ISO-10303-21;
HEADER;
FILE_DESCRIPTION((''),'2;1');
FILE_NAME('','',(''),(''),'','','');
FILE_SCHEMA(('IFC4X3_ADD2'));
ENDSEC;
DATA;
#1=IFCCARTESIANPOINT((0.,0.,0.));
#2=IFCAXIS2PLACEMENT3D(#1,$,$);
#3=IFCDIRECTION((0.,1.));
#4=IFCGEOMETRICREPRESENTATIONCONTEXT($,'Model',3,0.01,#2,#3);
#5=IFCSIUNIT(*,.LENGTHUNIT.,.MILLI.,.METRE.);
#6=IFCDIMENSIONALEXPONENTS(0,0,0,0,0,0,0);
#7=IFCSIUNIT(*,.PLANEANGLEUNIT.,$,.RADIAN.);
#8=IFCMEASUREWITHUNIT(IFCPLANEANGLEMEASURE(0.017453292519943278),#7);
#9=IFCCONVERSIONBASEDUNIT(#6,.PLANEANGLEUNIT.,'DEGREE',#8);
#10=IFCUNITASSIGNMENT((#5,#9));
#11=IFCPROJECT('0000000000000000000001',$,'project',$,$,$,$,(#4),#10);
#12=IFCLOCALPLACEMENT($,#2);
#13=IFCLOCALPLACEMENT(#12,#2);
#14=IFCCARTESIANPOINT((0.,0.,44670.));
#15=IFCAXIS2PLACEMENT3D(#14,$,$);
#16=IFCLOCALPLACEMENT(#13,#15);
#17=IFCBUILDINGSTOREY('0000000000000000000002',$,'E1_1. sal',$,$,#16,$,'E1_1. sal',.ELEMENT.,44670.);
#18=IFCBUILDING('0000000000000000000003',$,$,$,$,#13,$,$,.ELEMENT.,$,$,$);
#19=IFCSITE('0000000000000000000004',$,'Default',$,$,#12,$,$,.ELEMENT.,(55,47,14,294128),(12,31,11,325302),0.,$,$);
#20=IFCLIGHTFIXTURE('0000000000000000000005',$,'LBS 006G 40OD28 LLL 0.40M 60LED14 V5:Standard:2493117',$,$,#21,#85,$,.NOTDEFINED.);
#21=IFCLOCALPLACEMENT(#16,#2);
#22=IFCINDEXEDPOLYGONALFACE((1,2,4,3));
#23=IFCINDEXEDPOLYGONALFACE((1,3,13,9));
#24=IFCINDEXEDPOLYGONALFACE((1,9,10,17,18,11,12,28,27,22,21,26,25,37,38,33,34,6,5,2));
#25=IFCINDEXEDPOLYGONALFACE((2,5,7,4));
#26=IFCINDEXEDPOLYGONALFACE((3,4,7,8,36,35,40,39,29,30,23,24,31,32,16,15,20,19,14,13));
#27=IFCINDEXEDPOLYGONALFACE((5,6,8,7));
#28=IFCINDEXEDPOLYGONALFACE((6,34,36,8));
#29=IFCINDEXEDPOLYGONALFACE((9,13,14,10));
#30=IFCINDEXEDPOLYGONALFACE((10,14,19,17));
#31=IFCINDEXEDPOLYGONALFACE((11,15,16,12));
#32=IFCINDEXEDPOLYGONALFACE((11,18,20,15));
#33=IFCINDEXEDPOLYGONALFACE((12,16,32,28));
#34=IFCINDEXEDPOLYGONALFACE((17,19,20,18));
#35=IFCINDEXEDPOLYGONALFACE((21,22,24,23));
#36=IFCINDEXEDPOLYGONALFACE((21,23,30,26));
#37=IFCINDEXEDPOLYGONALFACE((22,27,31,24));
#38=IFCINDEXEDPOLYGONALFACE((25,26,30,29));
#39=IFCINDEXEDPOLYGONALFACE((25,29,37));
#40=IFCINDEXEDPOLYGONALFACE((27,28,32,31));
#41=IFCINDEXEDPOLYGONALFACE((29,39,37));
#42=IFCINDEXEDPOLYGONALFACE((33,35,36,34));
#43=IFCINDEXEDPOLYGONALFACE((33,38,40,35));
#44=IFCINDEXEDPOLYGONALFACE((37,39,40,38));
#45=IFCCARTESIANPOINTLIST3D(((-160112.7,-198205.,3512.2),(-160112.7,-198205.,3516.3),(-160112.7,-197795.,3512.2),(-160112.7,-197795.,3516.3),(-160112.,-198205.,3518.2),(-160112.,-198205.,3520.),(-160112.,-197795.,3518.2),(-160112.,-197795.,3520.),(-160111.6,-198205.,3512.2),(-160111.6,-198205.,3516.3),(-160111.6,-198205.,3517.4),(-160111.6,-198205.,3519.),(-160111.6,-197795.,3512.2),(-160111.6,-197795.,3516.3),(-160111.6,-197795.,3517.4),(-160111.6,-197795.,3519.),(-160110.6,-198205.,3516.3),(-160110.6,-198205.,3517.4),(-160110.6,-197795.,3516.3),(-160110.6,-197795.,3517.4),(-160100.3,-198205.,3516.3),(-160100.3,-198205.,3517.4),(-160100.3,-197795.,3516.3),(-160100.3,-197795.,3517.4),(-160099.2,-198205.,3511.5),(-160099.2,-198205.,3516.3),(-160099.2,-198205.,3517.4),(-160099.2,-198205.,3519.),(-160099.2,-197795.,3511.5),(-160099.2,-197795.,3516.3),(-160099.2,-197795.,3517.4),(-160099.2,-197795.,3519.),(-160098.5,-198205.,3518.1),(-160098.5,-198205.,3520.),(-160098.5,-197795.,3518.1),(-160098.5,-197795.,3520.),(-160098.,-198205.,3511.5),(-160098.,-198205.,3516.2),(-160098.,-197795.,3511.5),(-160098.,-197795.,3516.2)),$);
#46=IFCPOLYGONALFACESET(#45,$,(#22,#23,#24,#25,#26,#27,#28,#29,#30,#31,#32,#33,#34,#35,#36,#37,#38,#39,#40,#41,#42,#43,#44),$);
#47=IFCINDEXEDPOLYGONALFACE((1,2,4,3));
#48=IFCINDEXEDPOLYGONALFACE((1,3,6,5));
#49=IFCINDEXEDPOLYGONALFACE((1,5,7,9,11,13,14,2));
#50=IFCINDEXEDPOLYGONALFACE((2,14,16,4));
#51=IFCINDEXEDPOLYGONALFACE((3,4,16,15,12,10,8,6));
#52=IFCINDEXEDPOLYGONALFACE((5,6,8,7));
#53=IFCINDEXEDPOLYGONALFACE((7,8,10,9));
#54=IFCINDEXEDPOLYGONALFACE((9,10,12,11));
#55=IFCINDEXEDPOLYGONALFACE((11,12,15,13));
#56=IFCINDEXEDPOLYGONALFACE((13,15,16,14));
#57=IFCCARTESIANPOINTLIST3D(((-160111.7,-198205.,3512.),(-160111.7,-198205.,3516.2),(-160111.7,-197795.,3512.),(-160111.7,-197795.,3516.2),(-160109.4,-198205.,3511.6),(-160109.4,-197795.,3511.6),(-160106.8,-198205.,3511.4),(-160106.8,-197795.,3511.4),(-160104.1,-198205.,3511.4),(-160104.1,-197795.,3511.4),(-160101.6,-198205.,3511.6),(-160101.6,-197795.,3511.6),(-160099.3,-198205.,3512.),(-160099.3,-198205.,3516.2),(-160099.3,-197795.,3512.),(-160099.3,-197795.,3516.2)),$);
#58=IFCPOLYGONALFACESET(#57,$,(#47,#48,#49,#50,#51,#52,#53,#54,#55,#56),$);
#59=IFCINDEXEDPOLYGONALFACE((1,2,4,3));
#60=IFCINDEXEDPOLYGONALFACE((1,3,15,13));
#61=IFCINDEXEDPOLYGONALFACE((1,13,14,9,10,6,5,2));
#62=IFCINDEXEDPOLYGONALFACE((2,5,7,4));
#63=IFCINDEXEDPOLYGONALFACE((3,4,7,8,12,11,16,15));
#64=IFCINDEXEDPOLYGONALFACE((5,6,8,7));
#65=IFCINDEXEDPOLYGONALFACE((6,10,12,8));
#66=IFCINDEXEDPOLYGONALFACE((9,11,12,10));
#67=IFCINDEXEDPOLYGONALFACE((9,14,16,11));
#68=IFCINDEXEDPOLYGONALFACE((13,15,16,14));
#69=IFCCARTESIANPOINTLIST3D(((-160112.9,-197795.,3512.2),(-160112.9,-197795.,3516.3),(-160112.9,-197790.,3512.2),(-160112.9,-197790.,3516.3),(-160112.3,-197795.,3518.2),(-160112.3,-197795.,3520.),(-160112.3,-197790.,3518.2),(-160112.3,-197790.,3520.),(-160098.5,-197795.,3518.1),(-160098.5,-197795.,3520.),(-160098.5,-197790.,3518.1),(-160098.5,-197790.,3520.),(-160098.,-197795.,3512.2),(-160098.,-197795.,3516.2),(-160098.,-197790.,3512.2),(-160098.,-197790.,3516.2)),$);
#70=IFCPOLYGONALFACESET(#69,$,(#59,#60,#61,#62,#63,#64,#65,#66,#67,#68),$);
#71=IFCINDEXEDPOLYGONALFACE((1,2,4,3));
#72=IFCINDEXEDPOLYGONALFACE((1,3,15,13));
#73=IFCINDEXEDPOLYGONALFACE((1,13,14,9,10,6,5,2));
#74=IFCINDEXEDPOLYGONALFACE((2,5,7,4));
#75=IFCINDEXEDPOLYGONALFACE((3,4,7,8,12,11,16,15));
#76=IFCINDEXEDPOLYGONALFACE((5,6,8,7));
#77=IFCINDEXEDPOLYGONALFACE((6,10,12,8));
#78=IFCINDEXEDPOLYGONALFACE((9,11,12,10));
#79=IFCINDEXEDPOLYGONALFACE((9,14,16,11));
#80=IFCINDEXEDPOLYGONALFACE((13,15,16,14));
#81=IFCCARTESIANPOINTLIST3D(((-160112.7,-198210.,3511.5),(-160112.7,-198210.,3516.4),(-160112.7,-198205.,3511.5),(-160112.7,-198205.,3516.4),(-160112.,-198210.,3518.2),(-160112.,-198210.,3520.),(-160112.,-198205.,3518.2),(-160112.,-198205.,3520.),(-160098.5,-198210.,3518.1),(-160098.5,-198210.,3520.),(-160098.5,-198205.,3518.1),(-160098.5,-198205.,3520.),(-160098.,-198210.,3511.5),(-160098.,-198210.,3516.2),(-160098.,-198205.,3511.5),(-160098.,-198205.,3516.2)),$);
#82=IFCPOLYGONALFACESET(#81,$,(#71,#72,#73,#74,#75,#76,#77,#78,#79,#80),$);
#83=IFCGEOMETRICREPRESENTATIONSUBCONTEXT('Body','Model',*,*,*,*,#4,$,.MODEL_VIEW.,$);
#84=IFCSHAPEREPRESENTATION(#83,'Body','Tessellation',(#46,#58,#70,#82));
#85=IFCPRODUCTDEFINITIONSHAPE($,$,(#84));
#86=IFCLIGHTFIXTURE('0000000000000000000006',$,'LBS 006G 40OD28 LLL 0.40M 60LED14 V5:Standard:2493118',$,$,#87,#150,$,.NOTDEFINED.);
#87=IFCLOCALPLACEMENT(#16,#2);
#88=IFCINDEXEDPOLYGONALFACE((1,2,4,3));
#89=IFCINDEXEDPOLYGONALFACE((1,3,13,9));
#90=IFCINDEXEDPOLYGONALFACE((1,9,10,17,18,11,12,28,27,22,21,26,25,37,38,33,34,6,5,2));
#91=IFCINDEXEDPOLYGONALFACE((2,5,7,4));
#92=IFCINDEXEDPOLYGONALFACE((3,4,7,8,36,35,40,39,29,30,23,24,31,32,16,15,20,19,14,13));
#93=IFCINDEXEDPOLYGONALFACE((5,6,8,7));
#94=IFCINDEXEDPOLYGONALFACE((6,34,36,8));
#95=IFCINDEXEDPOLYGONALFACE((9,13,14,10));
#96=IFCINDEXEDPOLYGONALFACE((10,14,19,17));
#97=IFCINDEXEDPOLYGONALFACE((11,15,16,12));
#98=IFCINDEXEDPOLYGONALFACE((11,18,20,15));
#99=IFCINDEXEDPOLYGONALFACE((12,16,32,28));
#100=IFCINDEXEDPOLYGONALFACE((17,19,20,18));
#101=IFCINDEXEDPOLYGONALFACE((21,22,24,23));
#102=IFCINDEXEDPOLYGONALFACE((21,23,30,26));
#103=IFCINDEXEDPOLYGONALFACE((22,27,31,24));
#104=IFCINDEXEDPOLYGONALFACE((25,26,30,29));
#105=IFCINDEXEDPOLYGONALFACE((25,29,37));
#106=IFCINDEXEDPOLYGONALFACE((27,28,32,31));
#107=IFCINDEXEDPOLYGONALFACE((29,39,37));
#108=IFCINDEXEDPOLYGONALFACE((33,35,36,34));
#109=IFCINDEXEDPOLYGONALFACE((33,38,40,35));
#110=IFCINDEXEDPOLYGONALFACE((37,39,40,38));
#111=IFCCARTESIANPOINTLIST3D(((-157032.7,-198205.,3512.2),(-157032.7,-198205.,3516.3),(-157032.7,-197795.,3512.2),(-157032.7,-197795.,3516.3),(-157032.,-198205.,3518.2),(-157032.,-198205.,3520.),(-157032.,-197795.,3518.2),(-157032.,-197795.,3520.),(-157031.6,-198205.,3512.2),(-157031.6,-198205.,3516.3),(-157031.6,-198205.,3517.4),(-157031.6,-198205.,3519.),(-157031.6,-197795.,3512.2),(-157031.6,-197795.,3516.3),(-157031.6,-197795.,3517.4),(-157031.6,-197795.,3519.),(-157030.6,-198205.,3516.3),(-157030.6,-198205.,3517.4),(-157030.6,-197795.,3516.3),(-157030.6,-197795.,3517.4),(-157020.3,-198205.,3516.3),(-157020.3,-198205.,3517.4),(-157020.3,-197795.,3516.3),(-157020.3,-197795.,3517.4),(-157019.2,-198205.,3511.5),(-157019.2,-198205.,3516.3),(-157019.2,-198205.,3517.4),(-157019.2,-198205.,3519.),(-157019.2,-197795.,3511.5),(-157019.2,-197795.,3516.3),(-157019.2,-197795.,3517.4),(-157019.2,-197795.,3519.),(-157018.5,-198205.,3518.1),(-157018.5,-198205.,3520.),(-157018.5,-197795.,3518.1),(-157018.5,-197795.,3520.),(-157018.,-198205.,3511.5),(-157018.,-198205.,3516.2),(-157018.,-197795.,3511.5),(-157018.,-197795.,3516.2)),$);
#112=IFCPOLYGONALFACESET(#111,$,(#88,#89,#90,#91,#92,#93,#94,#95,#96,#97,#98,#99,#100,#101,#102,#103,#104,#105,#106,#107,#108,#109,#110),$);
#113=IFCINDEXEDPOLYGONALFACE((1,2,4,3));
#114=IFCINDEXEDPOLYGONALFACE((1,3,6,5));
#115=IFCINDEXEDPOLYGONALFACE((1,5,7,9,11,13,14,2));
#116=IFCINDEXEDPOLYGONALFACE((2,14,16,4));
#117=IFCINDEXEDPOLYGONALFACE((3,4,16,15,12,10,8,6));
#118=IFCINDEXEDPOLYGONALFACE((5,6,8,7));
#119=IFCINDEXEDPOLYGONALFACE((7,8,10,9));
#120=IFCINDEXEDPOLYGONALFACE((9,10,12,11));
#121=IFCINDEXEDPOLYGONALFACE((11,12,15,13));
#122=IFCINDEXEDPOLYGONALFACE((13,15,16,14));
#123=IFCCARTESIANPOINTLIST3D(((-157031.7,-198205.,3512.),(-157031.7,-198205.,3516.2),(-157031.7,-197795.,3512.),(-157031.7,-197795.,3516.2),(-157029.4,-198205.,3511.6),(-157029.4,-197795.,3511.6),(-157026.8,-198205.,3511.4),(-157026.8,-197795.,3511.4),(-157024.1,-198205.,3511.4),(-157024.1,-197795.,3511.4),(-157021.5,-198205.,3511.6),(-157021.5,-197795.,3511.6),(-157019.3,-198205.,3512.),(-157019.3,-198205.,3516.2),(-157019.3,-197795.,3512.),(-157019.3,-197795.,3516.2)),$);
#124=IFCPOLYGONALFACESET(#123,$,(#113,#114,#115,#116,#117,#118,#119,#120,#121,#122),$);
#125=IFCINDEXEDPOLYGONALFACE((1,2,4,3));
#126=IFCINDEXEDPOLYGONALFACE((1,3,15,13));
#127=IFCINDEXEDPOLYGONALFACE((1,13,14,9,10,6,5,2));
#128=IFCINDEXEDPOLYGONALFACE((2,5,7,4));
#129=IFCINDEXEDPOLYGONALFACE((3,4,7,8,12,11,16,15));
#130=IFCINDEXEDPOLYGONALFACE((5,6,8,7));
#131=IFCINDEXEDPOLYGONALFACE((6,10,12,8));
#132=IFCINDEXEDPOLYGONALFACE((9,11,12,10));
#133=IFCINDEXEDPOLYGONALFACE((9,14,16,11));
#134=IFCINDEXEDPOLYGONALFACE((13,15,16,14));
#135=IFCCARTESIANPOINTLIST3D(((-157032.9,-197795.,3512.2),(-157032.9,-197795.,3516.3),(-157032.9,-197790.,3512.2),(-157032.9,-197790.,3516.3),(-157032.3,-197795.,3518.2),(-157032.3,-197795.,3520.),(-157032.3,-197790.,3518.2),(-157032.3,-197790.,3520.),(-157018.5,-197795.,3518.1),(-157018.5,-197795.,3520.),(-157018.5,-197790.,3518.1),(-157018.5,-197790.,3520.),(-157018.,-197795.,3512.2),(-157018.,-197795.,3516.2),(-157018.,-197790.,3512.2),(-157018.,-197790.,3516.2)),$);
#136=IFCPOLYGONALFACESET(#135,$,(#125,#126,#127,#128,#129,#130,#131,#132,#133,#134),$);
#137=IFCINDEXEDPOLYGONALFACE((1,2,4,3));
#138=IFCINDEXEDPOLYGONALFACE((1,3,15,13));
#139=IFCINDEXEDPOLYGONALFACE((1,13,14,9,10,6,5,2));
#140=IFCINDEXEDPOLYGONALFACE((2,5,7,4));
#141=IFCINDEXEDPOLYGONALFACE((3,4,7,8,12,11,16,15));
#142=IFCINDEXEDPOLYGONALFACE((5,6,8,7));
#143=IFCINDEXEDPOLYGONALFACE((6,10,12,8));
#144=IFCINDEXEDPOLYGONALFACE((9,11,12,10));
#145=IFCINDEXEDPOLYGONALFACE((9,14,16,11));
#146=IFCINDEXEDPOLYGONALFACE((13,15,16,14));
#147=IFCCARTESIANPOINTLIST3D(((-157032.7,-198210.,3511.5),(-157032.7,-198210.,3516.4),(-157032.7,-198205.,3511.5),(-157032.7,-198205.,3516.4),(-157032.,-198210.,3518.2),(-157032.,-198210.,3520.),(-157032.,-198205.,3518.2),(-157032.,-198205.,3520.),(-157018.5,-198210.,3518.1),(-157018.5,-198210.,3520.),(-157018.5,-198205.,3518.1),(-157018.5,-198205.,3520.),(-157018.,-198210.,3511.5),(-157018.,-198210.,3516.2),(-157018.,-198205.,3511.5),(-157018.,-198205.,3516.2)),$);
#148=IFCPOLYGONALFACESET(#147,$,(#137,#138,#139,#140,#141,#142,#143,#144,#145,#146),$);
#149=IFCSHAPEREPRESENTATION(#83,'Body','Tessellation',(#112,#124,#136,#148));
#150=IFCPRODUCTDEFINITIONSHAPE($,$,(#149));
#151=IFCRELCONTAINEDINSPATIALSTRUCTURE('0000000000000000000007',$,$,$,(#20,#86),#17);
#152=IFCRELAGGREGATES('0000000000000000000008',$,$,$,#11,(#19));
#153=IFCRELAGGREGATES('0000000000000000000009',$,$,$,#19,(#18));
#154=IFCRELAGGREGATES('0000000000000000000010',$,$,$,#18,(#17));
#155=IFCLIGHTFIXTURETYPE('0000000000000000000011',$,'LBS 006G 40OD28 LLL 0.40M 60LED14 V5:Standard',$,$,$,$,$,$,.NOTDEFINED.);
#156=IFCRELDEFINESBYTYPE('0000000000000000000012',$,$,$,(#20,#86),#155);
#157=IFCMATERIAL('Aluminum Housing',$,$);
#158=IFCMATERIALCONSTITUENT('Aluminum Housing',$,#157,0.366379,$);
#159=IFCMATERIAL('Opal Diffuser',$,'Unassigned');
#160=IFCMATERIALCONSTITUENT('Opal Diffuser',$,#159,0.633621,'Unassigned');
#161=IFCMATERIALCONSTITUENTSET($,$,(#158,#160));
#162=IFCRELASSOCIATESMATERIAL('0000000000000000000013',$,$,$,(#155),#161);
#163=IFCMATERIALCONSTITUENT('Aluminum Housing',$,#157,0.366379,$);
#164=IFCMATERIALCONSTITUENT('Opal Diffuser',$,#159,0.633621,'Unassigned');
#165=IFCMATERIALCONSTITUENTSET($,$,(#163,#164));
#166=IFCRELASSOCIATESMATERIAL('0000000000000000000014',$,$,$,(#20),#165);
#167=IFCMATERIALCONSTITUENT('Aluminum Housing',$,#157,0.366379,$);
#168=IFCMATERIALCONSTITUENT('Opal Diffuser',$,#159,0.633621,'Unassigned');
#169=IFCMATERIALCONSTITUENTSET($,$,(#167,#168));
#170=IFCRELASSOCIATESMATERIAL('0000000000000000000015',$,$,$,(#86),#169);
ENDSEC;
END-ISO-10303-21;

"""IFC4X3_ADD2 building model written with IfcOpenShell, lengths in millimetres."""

from ifc_helpers import new_model, entity, si_unit, converted_unit, direction, frame, origin, place, context, subcontext, project, spatial, polyline, outline, extrude, source, transform, mapped, material, constituent, constituent_set, type_object, type_shapes, element, save


model = new_model("IFC4X3_ADD2")

# Units and contexts
model_context = context("Model", 3, precision=0.01, world=origin(), true_north=direction((0.0, 1.0)))
body_context = subcontext(model_context, "Body", "Model", "MODEL_VIEW")
ifc_project = project(units=[si_unit("LENGTHUNIT", "METRE", prefix="MILLI"), converted_unit("PLANEANGLEUNIT", "DEGREE", entity("IfcPlaneAngleMeasure", 0.017453292519943278), si_unit("PLANEANGLEUNIT", "RADIAN"), dimensions=[0, 0, 0, 0, 0, 0, 0])], contexts=[model_context])

# Site, building, storey
site_placement = place(None, origin())
site = spatial("IfcSite", under=ifc_project, at=site_placement, Name="Default", CompositionType="ELEMENT", RefLatitude=(55, 47, 14, 294128), RefLongitude=(12, 31, 11, 325302), RefElevation=0.0)
building_placement = place(site_placement, origin())
building = spatial("IfcBuilding", under=site, at=building_placement, CompositionType="ELEMENT")
storey_placement = place(building_placement, frame((0.0, 0.0, 44670.0)))
storey = spatial("IfcBuildingStorey", under=building, at=storey_placement, Name="E1_1. sal", LongName="E1_1. sal", CompositionType="ELEMENT", Elevation=44670.0)

# Light fixtures
ifc_material_1 = material(Name="Aluminum Housing")
ifc_constituent_1 = constituent(ifc_material_1, Name="Aluminum Housing", fraction=0.366379)
ifc_material_2 = material(Name="Opal Diffuser", Category="Unassigned")
ifc_constituent_2 = constituent(ifc_material_2, Name="Opal Diffuser", Category="Unassigned", fraction=0.633621)
ifc_constituent_set_1 = constituent_set(constituents=[ifc_constituent_1, ifc_constituent_2])
ifc_constituent_3 = constituent(ifc_material_1, Name="Aluminum Housing", fraction=0.366379)
ifc_constituent_4 = constituent(ifc_material_2, Name="Opal Diffuser", Category="Unassigned", fraction=0.633621)
ifc_constituent_set_2 = constituent_set(constituents=[ifc_constituent_3, ifc_constituent_4])
light_fixture_type = type_object("IfcLightFixtureType", Name="LBS 006G 40OD28 LLL 0.40M 60LED14 V5:Standard", PredefinedType="NOTDEFINED", material=ifc_constituent_set_2)
shared_shape_1 = source(origin(), body_context, "Body", "SweptSolid", [
    extrude(outline(polyline([(-5.0, -6.1), (-5.0, -7.4), (-0.3, -7.4), (1.7, -6.8), (3.5, -6.8), (3.5, 6.7), (1.8, 6.7), (-0.1, 7.3), (-4.2, 7.3), (-4.2, 6.2), (-0.1, 6.2), (-0.1, 5.2), (0.9, 5.2), (0.9, 6.2), (2.5, 6.2), (2.5, -6.1), (0.9, -6.1), (0.9, -5.1), (-0.1, -5.1), (-0.1, -6.1), (-5.0, -6.1)])), frame((-205.0, 0.1, 3.5), z_axis=(-1.0, 0.0, 0.0), x_axis=(0.0, 0.0, -1.0)), (0.0, 0.0, -1.0), 410.0),
    extrude(outline(polyline([(-0.8, -6.2), (3.4, -6.2), (3.4, 6.2), (-0.8, 6.2), (-1.2, 3.9), (-1.4, 1.4), (-1.4, -1.3), (-1.2, -3.9), (-0.8, -6.2)])), frame((-205.0, 0.0, 7.2), z_axis=(1.0, 0.0, 0.0), x_axis=(0.0, 0.0, -1.0)), (0.0, 0.0, 1.0), 410.0),
    extrude(outline(polyline([(-4.4, -7.5), (-0.3, -7.5), (1.5, -6.8), (3.3, -6.8), (3.3, 6.9), (1.5, 6.9), (-0.5, 7.4), (-4.4, 7.4), (-4.4, -7.5)])), frame((205.0, 0.0, 3.3), z_axis=(1.0, 0.0, 0.0), x_axis=(0.0, 0.0, -1.0)), (0.0, 0.0, 1.0), 5.0),
    extrude(outline(polyline([(-5.0, -7.4), (-0.1, -7.4), (1.7, -6.7), (3.5, -6.7), (3.5, 6.8), (1.6, 6.8), (-0.3, 7.3), (-5.0, 7.3), (-5.0, -7.4)])), frame((-210.0, 0.2, 3.5), z_axis=(1.0, 0.0, 0.0), x_axis=(0.0, 0.0, -1.0)), (0.0, 0.0, 1.0), 5.0),
])
type_shapes(light_fixture_type, [shared_shape_1])
light_fixture_1_placement = place(storey_placement, frame((-160105.5, -198000.0, 3520.0), z_axis=(0.0, 0.0, -1.0), x_axis=(0.0, 1.0, 0.0)))
element("IfcLightFixture", 1, at=light_fixture_1_placement, inside=storey, type_object=light_fixture_type, material=ifc_constituent_set_1, Name="LBS 006G 40OD28 LLL 0.40M 60LED14 V5:Standard:2493117", PredefinedType="NOTDEFINED", context=body_context, shape_type="MappedRepresentation", body=[
    mapped(shared_shape_1, transform((0.0, 0.0, 0.0), scale=1.0)),
])
ifc_constituent_5 = constituent(ifc_material_1, Name="Aluminum Housing", fraction=0.366379)
ifc_constituent_6 = constituent(ifc_material_2, Name="Opal Diffuser", Category="Unassigned", fraction=0.633621)
ifc_constituent_set_3 = constituent_set(constituents=[ifc_constituent_5, ifc_constituent_6])
light_fixture_2_placement = place(storey_placement, frame((-157025.5, -198000.0, 3520.0), z_axis=(0.0, 0.0, -1.0), x_axis=(0.0, 1.0, 0.0)))
element("IfcLightFixture", 2, at=light_fixture_2_placement, inside=storey, type_object=light_fixture_type, material=ifc_constituent_set_3, Name="LBS 006G 40OD28 LLL 0.40M 60LED14 V5:Standard:2493118", PredefinedType="NOTDEFINED", context=body_context, shape_type="MappedRepresentation", body=[
    mapped(shared_shape_1, transform((0.0, 0.0, 0.0), scale=1.0)),
])

save(model, "model.ifc")
